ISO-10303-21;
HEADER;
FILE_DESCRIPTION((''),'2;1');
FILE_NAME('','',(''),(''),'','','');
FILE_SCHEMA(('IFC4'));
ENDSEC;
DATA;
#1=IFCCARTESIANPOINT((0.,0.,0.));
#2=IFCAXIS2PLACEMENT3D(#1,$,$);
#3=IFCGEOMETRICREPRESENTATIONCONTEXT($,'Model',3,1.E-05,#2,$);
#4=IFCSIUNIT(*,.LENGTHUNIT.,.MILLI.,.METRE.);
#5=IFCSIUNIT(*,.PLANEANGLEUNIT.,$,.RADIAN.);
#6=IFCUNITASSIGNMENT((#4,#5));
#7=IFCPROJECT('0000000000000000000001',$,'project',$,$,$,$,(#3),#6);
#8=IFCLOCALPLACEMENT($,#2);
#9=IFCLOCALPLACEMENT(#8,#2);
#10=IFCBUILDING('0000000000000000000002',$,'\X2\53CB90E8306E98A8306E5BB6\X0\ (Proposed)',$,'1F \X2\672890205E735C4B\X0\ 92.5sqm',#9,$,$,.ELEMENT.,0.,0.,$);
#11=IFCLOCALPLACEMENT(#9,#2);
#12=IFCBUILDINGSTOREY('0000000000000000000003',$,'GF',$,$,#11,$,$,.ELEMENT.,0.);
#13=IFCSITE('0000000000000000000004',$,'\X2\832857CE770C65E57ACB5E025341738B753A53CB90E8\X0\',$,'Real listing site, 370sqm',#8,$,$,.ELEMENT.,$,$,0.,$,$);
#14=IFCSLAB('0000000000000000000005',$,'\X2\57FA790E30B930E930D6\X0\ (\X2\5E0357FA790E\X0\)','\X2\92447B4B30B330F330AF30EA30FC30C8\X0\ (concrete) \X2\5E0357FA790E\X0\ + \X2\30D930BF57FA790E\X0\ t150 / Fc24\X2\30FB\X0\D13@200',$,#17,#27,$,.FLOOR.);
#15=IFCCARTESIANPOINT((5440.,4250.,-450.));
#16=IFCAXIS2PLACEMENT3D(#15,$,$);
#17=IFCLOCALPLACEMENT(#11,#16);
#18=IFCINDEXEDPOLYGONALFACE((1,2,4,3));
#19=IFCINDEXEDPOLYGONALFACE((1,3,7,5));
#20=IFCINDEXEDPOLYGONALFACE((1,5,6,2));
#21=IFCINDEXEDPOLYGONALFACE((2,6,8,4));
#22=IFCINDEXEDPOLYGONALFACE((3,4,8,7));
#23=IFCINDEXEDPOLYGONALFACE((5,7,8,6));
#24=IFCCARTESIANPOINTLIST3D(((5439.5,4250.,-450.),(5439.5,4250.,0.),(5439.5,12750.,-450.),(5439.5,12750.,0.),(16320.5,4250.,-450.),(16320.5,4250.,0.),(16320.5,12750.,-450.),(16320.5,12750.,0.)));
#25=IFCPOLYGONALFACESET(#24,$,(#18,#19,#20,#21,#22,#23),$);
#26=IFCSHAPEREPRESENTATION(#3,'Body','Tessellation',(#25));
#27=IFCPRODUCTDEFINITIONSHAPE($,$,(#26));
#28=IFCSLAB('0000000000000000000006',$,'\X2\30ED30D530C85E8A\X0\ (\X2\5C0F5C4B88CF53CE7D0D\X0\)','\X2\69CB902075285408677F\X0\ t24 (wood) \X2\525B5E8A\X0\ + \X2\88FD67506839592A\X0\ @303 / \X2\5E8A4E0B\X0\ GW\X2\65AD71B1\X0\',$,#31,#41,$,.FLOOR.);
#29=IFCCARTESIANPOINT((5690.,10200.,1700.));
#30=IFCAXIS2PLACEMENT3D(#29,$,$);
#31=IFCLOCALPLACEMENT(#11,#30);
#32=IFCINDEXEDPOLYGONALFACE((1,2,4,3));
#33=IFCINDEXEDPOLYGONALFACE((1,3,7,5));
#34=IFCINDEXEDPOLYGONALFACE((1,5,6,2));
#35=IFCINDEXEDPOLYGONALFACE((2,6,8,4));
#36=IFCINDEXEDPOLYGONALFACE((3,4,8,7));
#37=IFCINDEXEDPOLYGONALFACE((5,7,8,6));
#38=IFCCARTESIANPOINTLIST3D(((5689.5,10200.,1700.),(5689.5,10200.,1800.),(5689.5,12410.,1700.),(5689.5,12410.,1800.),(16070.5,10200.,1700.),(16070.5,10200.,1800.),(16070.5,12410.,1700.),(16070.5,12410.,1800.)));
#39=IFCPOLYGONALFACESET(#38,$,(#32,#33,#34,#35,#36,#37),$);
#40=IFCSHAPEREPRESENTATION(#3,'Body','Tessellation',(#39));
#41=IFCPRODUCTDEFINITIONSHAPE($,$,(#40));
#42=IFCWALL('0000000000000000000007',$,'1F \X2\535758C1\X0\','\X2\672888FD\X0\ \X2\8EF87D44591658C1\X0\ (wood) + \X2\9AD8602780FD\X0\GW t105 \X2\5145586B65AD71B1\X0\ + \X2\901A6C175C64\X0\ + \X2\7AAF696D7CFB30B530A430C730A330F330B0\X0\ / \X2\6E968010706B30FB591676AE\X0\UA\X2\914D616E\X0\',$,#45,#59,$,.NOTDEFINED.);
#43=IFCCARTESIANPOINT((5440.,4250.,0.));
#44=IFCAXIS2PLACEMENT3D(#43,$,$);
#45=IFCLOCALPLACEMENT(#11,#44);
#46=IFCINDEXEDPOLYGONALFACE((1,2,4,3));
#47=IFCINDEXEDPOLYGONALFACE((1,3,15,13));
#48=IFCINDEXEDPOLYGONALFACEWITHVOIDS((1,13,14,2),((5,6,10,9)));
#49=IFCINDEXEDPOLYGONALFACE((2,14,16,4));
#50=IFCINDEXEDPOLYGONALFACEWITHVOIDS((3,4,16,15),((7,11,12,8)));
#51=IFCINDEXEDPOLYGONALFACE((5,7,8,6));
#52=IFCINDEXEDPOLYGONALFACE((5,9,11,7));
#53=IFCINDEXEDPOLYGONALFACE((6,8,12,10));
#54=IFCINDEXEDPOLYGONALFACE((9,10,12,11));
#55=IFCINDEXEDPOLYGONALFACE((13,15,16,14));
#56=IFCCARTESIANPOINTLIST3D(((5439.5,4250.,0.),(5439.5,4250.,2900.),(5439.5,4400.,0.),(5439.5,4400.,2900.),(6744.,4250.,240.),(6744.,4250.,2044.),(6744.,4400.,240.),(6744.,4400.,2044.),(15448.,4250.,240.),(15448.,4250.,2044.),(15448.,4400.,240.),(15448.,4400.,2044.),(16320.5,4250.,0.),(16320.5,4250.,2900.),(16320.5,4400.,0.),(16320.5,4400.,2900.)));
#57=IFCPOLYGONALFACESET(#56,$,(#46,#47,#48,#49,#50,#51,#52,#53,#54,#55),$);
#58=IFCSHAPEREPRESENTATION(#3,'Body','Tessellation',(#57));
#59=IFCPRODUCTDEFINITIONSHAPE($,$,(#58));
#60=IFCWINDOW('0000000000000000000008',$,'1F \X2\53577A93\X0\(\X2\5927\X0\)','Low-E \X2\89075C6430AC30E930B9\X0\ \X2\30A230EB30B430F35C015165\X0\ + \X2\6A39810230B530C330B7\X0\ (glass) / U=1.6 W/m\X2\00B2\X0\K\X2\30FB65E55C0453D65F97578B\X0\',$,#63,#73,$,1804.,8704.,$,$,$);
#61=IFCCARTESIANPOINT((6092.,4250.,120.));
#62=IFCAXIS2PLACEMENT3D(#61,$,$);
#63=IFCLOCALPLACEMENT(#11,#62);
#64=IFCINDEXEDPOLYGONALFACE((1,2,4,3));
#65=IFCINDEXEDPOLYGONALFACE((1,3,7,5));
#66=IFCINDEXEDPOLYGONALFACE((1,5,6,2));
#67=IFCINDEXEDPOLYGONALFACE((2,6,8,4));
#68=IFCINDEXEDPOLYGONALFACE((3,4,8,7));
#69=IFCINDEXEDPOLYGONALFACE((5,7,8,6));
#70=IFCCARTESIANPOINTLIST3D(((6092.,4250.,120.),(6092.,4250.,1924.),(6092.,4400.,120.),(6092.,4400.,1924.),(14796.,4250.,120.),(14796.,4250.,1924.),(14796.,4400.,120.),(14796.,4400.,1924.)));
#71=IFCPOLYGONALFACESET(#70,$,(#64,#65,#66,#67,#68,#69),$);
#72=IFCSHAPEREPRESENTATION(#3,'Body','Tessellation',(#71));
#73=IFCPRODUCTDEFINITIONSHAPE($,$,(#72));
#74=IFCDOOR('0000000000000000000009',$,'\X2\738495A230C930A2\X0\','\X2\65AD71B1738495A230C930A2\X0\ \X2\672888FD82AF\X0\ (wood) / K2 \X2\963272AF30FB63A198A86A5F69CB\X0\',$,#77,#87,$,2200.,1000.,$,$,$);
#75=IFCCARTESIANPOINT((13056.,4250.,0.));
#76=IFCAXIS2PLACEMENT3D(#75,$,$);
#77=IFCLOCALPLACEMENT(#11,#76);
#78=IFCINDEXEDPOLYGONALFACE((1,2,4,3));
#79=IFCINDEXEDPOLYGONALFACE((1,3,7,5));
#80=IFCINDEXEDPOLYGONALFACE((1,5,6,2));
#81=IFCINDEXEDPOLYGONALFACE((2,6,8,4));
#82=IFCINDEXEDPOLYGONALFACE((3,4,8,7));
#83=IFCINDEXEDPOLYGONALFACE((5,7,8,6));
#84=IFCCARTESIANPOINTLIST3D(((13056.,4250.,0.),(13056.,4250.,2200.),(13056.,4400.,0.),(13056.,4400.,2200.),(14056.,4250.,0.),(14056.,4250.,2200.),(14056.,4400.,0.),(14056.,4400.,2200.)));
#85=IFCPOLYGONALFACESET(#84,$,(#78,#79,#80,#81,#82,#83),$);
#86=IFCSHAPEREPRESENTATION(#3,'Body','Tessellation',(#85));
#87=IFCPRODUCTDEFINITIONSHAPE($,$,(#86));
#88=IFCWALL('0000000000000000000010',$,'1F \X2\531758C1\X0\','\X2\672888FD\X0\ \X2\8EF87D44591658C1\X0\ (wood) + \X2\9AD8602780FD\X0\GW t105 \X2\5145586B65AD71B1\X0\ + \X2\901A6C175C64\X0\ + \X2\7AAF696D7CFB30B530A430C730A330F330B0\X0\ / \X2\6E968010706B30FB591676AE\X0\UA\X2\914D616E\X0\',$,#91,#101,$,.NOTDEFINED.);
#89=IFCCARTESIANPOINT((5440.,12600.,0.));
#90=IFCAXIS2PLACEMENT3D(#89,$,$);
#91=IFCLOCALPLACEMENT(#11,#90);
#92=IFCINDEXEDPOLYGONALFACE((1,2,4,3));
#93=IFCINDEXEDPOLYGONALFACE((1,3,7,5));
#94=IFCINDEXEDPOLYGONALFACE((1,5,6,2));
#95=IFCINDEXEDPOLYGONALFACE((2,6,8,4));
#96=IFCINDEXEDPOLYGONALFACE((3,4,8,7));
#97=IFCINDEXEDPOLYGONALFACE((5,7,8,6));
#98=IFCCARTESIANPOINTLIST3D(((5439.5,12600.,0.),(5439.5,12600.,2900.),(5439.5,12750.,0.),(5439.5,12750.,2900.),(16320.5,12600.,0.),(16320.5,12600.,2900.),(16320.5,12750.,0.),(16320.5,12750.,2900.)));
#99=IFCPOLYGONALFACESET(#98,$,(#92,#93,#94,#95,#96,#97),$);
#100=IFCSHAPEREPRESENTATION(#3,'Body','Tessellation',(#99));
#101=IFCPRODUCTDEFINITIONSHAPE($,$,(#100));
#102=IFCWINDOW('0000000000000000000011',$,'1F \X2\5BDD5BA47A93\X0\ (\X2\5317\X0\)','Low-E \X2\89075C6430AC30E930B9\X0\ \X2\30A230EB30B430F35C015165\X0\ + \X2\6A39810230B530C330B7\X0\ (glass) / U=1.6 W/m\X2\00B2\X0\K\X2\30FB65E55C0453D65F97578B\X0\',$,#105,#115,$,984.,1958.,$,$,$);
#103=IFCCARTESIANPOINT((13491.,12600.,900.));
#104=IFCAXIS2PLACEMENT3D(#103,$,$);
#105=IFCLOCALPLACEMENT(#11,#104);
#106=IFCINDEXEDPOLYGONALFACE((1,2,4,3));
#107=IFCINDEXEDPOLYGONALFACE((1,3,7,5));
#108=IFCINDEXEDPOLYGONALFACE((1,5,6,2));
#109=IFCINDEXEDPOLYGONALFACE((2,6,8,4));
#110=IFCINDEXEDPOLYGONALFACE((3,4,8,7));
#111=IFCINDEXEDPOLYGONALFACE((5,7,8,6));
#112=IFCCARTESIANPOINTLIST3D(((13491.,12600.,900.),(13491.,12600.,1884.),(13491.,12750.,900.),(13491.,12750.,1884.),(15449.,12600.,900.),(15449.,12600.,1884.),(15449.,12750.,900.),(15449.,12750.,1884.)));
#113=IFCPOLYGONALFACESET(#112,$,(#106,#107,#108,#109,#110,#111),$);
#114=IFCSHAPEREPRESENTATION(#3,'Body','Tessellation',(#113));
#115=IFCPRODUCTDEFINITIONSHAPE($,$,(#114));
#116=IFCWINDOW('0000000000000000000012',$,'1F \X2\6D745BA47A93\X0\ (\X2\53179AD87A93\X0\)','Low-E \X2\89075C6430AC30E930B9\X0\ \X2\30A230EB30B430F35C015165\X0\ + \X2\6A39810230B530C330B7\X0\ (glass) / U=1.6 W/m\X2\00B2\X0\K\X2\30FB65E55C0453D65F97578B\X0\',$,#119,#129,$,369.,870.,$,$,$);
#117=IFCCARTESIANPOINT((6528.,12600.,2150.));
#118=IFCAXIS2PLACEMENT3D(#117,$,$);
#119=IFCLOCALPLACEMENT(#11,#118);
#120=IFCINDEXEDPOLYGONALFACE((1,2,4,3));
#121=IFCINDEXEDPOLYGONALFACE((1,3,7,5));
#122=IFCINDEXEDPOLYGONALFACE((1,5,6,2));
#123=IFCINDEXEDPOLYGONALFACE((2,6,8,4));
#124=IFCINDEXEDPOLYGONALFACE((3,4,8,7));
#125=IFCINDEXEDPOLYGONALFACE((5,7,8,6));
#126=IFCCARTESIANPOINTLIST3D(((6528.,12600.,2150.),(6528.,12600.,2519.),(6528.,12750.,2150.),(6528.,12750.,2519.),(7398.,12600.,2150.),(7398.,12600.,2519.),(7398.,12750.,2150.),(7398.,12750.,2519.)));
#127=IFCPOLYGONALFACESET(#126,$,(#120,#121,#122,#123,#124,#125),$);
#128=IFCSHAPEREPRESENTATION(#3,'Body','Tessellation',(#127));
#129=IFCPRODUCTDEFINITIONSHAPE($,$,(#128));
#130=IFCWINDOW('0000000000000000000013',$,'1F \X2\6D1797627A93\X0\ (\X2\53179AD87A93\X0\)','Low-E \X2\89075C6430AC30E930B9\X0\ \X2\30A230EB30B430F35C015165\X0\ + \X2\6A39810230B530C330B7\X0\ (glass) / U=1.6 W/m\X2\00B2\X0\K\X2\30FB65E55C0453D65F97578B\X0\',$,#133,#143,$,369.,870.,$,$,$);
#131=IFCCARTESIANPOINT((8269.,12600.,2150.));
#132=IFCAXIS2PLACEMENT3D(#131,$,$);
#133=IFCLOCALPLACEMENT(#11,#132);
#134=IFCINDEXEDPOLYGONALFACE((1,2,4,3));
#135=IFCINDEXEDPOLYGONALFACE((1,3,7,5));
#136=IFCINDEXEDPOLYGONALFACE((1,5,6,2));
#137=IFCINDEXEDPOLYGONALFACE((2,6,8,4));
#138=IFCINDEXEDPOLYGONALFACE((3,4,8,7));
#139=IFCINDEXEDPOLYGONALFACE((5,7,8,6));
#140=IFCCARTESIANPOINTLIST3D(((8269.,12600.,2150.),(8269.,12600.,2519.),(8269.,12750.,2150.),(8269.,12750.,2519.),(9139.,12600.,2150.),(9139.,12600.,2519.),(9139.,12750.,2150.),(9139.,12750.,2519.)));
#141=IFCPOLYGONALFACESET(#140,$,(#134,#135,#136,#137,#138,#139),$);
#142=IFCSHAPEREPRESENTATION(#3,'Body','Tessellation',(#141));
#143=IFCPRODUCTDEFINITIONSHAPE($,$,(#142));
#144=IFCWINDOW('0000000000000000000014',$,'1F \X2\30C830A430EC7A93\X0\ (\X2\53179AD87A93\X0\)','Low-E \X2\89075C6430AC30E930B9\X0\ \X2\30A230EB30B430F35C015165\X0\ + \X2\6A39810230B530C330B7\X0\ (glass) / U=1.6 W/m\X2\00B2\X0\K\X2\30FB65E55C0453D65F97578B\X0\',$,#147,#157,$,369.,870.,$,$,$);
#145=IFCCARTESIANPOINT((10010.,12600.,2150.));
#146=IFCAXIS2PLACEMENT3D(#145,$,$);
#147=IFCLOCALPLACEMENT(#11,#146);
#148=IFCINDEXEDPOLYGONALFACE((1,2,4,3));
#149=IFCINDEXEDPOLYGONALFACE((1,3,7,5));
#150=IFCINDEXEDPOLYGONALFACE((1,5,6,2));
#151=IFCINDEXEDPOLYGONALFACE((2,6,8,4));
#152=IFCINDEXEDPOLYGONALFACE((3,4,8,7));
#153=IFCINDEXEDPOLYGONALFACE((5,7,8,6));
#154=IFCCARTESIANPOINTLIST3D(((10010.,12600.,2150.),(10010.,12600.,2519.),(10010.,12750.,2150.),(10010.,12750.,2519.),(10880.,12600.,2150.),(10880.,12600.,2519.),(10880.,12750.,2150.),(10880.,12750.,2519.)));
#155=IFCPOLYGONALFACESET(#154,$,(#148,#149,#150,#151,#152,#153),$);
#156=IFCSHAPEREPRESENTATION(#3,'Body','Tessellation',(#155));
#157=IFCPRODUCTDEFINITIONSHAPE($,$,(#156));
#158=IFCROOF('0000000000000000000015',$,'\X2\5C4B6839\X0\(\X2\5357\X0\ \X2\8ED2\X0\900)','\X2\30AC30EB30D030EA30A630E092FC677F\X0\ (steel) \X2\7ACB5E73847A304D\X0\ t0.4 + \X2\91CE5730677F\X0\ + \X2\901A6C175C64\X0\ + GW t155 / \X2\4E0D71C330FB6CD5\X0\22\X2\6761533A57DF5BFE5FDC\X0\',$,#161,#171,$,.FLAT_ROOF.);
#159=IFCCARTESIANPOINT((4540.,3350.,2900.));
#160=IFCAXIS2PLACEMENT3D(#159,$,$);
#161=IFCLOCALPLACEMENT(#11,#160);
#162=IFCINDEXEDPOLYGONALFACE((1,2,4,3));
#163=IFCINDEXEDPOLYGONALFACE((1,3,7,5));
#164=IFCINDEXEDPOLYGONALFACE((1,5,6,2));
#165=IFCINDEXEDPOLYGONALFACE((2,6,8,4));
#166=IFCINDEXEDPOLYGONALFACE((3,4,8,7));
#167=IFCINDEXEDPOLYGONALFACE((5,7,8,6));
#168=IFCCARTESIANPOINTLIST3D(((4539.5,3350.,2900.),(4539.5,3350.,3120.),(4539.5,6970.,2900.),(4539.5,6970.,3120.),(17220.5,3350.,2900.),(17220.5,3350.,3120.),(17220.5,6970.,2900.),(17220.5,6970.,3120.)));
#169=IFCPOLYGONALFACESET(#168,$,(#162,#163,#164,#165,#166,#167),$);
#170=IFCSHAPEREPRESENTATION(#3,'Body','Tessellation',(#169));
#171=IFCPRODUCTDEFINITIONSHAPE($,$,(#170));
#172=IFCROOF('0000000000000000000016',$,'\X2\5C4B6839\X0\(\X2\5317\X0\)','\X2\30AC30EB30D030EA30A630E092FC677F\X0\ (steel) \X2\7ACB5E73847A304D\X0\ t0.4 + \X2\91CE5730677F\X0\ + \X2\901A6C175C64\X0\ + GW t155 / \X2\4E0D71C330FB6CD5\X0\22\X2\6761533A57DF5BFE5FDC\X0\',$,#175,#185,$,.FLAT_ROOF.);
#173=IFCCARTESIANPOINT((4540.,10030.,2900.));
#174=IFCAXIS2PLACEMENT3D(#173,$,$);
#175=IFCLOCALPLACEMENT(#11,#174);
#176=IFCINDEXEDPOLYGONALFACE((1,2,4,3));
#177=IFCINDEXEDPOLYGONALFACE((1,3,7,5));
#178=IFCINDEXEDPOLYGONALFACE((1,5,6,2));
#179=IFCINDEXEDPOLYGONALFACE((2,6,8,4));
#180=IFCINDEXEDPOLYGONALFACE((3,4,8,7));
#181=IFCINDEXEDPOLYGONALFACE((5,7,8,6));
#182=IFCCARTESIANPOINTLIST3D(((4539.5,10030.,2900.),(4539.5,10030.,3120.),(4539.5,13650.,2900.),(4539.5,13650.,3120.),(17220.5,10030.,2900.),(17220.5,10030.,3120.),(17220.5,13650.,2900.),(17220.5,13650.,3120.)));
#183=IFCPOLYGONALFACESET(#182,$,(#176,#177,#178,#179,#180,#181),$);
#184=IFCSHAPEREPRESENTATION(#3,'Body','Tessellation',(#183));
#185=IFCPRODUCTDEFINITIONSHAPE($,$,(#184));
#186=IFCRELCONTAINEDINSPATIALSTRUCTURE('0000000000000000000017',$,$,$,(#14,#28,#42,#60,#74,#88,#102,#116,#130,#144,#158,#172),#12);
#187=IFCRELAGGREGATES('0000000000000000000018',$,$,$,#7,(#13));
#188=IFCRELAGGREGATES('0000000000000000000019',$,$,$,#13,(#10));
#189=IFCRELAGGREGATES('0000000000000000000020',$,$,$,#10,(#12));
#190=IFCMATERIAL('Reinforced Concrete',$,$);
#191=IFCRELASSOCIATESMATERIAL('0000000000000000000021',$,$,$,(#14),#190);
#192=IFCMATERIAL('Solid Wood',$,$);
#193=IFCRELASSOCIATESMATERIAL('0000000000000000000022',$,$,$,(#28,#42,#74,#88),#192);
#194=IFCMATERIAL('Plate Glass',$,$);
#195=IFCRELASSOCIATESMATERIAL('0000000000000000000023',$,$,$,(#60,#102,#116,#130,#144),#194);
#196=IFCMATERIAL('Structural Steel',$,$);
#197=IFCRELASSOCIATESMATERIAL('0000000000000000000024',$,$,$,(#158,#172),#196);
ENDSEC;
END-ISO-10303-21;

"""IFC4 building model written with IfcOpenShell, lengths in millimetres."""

from ifc_helpers import new_model, si_unit, frame, frame_2d, origin, place, context, project, spatial, rectangle, extrude, material, element, fill, save


model = new_model("IFC4")

# Units and contexts
model_context = context("Model", 3, precision=1e-05, world=origin())
ifc_project = project(units=[si_unit("LENGTHUNIT", "METRE", prefix="MILLI"), si_unit("PLANEANGLEUNIT", "RADIAN")], contexts=[model_context])

# Site, building, storey
site_placement = place(None, origin())
site = spatial("IfcSite", under=ifc_project, at=site_placement, Name="茨城県日立市十王町友部", ObjectType="Real listing site, 370sqm", CompositionType="ELEMENT", RefElevation=0.0)
building_placement = place(site_placement, origin())
building = spatial("IfcBuilding", under=site, at=building_placement, Name="友部の風の家 (Proposed)", ObjectType="1F 木造平屋 92.5sqm", CompositionType="ELEMENT", ElevationOfRefHeight=0.0, ElevationOfTerrain=0.0)
storey_placement = place(building_placement, origin())
storey = spatial("IfcBuildingStorey", under=building, at=storey_placement, Name="GF", CompositionType="ELEMENT", Elevation=0.0)

# Slabs
ifc_material_1 = material(Name="Reinforced Concrete")
slab_1_placement = place(storey_placement, frame((5440.0, 4250.0, -450.0)))
element("IfcSlab", 1, at=slab_1_placement, inside=storey, material=ifc_material_1, Name="基礎スラブ (布基礎)", Description="鉄筋コンクリート (concrete) 布基礎 + ベタ基礎 t150 / Fc24・D13@200", PredefinedType="FLOOR", context=model_context, shape_type="SweptSolid", body=[
    extrude(rectangle(XDim=10881.0, YDim=8500.0, at=frame_2d((5440.0, 4250.0))), frame((5440.0, 4250.0, -450.0)), (0.0, 0.0, 1.0), 450.0),
])
ifc_material_2 = material(Name="Solid Wood")
slab_2_placement = place(storey_placement, frame((5690.0, 10200.0, 1700.0)))
element("IfcSlab", 2, at=slab_2_placement, inside=storey, material=ifc_material_2, Name="ロフト床 (小屋裏収納)", Description="構造用合板 t24 (wood) 剛床 + 製材根太 @303 / 床下 GW断熱", PredefinedType="FLOOR", context=model_context, shape_type="SweptSolid", body=[
    extrude(rectangle(XDim=10381.0, YDim=2210.0, at=frame_2d((5190.0, 1105.0))), frame((5690.0, 10200.0, 1700.0)), (0.0, 0.0, 1.0), 100.0),
])

# Wall, openings, window, door
wall_1_placement = place(storey_placement, frame((5440.0, 4250.0, 0.0)))
wall_1 = element("IfcWall", 3, at=wall_1_placement, inside=storey, material=ifc_material_2, Name="1F 南壁", Description="木製 軸組外壁 (wood) + 高性能GW t105 充填断熱 + 通気層 + 窯業系サイディング / 準耐火・外皮UA配慮", PredefinedType="NOTDEFINED", context=model_context, shape_type="SweptSolid", body=[
    extrude(rectangle(XDim=10881.0, YDim=150.0, at=frame_2d((5440.0, 75.0))), frame((5440.0, 4250.0, 0.0)), (0.0, 0.0, 1.0), 2900.0),
])
opening_1_placement = place(storey_placement, frame((6092.0, 4250.0, 120.0)))
opening_1 = element("IfcOpeningElement", 4, at=opening_1_placement, cuts=wall_1, PredefinedType="NOTDEFINED", context=model_context, shape_type="SweptSolid", body=[
    extrude(rectangle(XDim=8704.0, YDim=150.0, at=frame_2d((4352.0, 75.0))), frame((6092.0, 4250.0, 120.0)), (0.0, 0.0, 1.0), 1804.0),
])
opening_2_placement = place(storey_placement, frame((13056.0, 4250.0, 0.0)))
opening_2 = element("IfcOpeningElement", 5, at=opening_2_placement, cuts=wall_1, PredefinedType="NOTDEFINED", context=model_context, shape_type="SweptSolid", body=[
    extrude(rectangle(XDim=1000.0, YDim=150.0, at=frame_2d((500.0, 75.0))), frame((13056.0, 4250.0, 0.0)), (0.0, 0.0, 1.0), 2200.0),
])
ifc_material_3 = material(Name="Plate Glass")
window_1_placement = place(storey_placement, frame((6092.0, 4250.0, 120.0)))
window_1 = element("IfcWindow", 6, at=window_1_placement, inside=storey, material=ifc_material_3, Name="1F 南窓(大)", Description="Low-E 複層ガラス アルゴン封入 + 樹脂サッシ (glass) / U=1.6 W/m²K・日射取得型", OverallHeight=1804.0, OverallWidth=8704.0, context=model_context, shape_type="SweptSolid", body=[
    extrude(rectangle(XDim=8704.0, YDim=150.0, at=frame_2d((4352.0, 75.0))), frame((6092.0, 4250.0, 120.0)), (0.0, 0.0, 1.0), 1804.0),
])
fill(opening_1, window_1)
door_1_placement = place(storey_placement, frame((13056.0, 4250.0, 0.0)))
door_1 = element("IfcDoor", 7, at=door_1_placement, inside=storey, material=ifc_material_2, Name="玄関ドア", Description="断熱玄関ドア 木製芯 (wood) / K2 防犯・採風機構", OverallHeight=2200.0, OverallWidth=1000.0, context=model_context, shape_type="SweptSolid", body=[
    extrude(rectangle(XDim=1000.0, YDim=150.0, at=frame_2d((500.0, 75.0))), frame((13056.0, 4250.0, 0.0)), (0.0, 0.0, 1.0), 2200.0),
])
fill(opening_2, door_1)

# Wall, openings, windows
wall_2_placement = place(storey_placement, frame((5440.0, 12600.0, 0.0)))
wall_2 = element("IfcWall", 8, at=wall_2_placement, inside=storey, material=ifc_material_2, Name="1F 北壁", Description="木製 軸組外壁 (wood) + 高性能GW t105 充填断熱 + 通気層 + 窯業系サイディング / 準耐火・外皮UA配慮", PredefinedType="NOTDEFINED", context=model_context, shape_type="SweptSolid", body=[
    extrude(rectangle(XDim=10881.0, YDim=150.0, at=frame_2d((5440.0, 75.0))), frame((5440.0, 12600.0, 0.0)), (0.0, 0.0, 1.0), 2900.0),
])
opening_3_placement = place(storey_placement, frame((13491.0, 12600.0, 900.0)))
opening_3 = element("IfcOpeningElement", 9, at=opening_3_placement, cuts=wall_2, PredefinedType="NOTDEFINED", context=model_context, shape_type="SweptSolid", body=[
    extrude(rectangle(XDim=1958.0, YDim=150.0, at=frame_2d((979.0, 75.0))), frame((13491.0, 12600.0, 900.0)), (0.0, 0.0, 1.0), 984.0),
])
opening_4_placement = place(storey_placement, frame((6528.0, 12600.0, 2150.0)))
opening_4 = element("IfcOpeningElement", 10, at=opening_4_placement, cuts=wall_2, PredefinedType="NOTDEFINED", context=model_context, shape_type="SweptSolid", body=[
    extrude(rectangle(XDim=870.0, YDim=150.0, at=frame_2d((435.0, 75.0))), frame((6528.0, 12600.0, 2150.0)), (0.0, 0.0, 1.0), 369.0),
])
opening_5_placement = place(storey_placement, frame((8269.0, 12600.0, 2150.0)))
opening_5 = element("IfcOpeningElement", 11, at=opening_5_placement, cuts=wall_2, PredefinedType="NOTDEFINED", context=model_context, shape_type="SweptSolid", body=[
    extrude(rectangle(XDim=870.0, YDim=150.0, at=frame_2d((435.0, 75.0))), frame((8269.0, 12600.0, 2150.0)), (0.0, 0.0, 1.0), 369.0),
])
opening_6_placement = place(storey_placement, frame((10010.0, 12600.0, 2150.0)))
opening_6 = element("IfcOpeningElement", 12, at=opening_6_placement, cuts=wall_2, PredefinedType="NOTDEFINED", context=model_context, shape_type="SweptSolid", body=[
    extrude(rectangle(XDim=870.0, YDim=150.0, at=frame_2d((435.0, 75.0))), frame((10010.0, 12600.0, 2150.0)), (0.0, 0.0, 1.0), 369.0),
])
window_2_placement = place(storey_placement, frame((13491.0, 12600.0, 900.0)))
window_2 = element("IfcWindow", 13, at=window_2_placement, inside=storey, material=ifc_material_3, Name="1F 寝室窓 (北)", Description="Low-E 複層ガラス アルゴン封入 + 樹脂サッシ (glass) / U=1.6 W/m²K・日射取得型", OverallHeight=984.0, OverallWidth=1958.0, context=model_context, shape_type="SweptSolid", body=[
    extrude(rectangle(XDim=1958.0, YDim=150.0, at=frame_2d((979.0, 75.0))), frame((13491.0, 12600.0, 900.0)), (0.0, 0.0, 1.0), 984.0),
])
fill(opening_3, window_2)
window_3_placement = place(storey_placement, frame((6528.0, 12600.0, 2150.0)))
window_3 = element("IfcWindow", 14, at=window_3_placement, inside=storey, material=ifc_material_3, Name="1F 浴室窓 (北高窓)", Description="Low-E 複層ガラス アルゴン封入 + 樹脂サッシ (glass) / U=1.6 W/m²K・日射取得型", OverallHeight=369.0, OverallWidth=870.0, context=model_context, shape_type="SweptSolid", body=[
    extrude(rectangle(XDim=870.0, YDim=150.0, at=frame_2d((435.0, 75.0))), frame((6528.0, 12600.0, 2150.0)), (0.0, 0.0, 1.0), 369.0),
])
fill(opening_4, window_3)
window_4_placement = place(storey_placement, frame((8269.0, 12600.0, 2150.0)))
window_4 = element("IfcWindow", 15, at=window_4_placement, inside=storey, material=ifc_material_3, Name="1F 洗面窓 (北高窓)", Description="Low-E 複層ガラス アルゴン封入 + 樹脂サッシ (glass) / U=1.6 W/m²K・日射取得型", OverallHeight=369.0, OverallWidth=870.0, context=model_context, shape_type="SweptSolid", body=[
    extrude(rectangle(XDim=870.0, YDim=150.0, at=frame_2d((435.0, 75.0))), frame((8269.0, 12600.0, 2150.0)), (0.0, 0.0, 1.0), 369.0),
])
fill(opening_5, window_4)
window_5_placement = place(storey_placement, frame((10010.0, 12600.0, 2150.0)))
window_5 = element("IfcWindow", 16, at=window_5_placement, inside=storey, material=ifc_material_3, Name="1F トイレ窓 (北高窓)", Description="Low-E 複層ガラス アルゴン封入 + 樹脂サッシ (glass) / U=1.6 W/m²K・日射取得型", OverallHeight=369.0, OverallWidth=870.0, context=model_context, shape_type="SweptSolid", body=[
    extrude(rectangle(XDim=870.0, YDim=150.0, at=frame_2d((435.0, 75.0))), frame((10010.0, 12600.0, 2150.0)), (0.0, 0.0, 1.0), 369.0),
])
fill(opening_6, window_5)

# Roofs
ifc_material_4 = material(Name="Structural Steel")
roof_1_placement = place(storey_placement, frame((4540.0, 3350.0, 2900.0)))
element("IfcRoof", 17, at=roof_1_placement, inside=storey, material=ifc_material_4, Name="屋根(南 軒900)", Description="ガルバリウム鋼板 (steel) 立平葺き t0.4 + 野地板 + 通気層 + GW t155 / 不燃・法22条区域対応", PredefinedType="FLAT_ROOF", context=model_context, shape_type="SweptSolid", body=[
    extrude(rectangle(XDim=12681.0, YDim=3620.0, at=frame_2d((6340.0, 1810.0))), frame((4540.0, 3350.0, 2900.0)), (0.0, 0.0, 1.0), 220.0),
])
roof_2_placement = place(storey_placement, frame((4540.0, 10030.0, 2900.0)))
element("IfcRoof", 18, at=roof_2_placement, inside=storey, material=ifc_material_4, Name="屋根(北)", Description="ガルバリウム鋼板 (steel) 立平葺き t0.4 + 野地板 + 通気層 + GW t155 / 不燃・法22条区域対応", PredefinedType="FLAT_ROOF", context=model_context, shape_type="SweptSolid", body=[
    extrude(rectangle(XDim=12681.0, YDim=3620.0, at=frame_2d((6340.0, 1810.0))), frame((4540.0, 10030.0, 2900.0)), (0.0, 0.0, 1.0), 220.0),
])

save(model, "model.ifc")
